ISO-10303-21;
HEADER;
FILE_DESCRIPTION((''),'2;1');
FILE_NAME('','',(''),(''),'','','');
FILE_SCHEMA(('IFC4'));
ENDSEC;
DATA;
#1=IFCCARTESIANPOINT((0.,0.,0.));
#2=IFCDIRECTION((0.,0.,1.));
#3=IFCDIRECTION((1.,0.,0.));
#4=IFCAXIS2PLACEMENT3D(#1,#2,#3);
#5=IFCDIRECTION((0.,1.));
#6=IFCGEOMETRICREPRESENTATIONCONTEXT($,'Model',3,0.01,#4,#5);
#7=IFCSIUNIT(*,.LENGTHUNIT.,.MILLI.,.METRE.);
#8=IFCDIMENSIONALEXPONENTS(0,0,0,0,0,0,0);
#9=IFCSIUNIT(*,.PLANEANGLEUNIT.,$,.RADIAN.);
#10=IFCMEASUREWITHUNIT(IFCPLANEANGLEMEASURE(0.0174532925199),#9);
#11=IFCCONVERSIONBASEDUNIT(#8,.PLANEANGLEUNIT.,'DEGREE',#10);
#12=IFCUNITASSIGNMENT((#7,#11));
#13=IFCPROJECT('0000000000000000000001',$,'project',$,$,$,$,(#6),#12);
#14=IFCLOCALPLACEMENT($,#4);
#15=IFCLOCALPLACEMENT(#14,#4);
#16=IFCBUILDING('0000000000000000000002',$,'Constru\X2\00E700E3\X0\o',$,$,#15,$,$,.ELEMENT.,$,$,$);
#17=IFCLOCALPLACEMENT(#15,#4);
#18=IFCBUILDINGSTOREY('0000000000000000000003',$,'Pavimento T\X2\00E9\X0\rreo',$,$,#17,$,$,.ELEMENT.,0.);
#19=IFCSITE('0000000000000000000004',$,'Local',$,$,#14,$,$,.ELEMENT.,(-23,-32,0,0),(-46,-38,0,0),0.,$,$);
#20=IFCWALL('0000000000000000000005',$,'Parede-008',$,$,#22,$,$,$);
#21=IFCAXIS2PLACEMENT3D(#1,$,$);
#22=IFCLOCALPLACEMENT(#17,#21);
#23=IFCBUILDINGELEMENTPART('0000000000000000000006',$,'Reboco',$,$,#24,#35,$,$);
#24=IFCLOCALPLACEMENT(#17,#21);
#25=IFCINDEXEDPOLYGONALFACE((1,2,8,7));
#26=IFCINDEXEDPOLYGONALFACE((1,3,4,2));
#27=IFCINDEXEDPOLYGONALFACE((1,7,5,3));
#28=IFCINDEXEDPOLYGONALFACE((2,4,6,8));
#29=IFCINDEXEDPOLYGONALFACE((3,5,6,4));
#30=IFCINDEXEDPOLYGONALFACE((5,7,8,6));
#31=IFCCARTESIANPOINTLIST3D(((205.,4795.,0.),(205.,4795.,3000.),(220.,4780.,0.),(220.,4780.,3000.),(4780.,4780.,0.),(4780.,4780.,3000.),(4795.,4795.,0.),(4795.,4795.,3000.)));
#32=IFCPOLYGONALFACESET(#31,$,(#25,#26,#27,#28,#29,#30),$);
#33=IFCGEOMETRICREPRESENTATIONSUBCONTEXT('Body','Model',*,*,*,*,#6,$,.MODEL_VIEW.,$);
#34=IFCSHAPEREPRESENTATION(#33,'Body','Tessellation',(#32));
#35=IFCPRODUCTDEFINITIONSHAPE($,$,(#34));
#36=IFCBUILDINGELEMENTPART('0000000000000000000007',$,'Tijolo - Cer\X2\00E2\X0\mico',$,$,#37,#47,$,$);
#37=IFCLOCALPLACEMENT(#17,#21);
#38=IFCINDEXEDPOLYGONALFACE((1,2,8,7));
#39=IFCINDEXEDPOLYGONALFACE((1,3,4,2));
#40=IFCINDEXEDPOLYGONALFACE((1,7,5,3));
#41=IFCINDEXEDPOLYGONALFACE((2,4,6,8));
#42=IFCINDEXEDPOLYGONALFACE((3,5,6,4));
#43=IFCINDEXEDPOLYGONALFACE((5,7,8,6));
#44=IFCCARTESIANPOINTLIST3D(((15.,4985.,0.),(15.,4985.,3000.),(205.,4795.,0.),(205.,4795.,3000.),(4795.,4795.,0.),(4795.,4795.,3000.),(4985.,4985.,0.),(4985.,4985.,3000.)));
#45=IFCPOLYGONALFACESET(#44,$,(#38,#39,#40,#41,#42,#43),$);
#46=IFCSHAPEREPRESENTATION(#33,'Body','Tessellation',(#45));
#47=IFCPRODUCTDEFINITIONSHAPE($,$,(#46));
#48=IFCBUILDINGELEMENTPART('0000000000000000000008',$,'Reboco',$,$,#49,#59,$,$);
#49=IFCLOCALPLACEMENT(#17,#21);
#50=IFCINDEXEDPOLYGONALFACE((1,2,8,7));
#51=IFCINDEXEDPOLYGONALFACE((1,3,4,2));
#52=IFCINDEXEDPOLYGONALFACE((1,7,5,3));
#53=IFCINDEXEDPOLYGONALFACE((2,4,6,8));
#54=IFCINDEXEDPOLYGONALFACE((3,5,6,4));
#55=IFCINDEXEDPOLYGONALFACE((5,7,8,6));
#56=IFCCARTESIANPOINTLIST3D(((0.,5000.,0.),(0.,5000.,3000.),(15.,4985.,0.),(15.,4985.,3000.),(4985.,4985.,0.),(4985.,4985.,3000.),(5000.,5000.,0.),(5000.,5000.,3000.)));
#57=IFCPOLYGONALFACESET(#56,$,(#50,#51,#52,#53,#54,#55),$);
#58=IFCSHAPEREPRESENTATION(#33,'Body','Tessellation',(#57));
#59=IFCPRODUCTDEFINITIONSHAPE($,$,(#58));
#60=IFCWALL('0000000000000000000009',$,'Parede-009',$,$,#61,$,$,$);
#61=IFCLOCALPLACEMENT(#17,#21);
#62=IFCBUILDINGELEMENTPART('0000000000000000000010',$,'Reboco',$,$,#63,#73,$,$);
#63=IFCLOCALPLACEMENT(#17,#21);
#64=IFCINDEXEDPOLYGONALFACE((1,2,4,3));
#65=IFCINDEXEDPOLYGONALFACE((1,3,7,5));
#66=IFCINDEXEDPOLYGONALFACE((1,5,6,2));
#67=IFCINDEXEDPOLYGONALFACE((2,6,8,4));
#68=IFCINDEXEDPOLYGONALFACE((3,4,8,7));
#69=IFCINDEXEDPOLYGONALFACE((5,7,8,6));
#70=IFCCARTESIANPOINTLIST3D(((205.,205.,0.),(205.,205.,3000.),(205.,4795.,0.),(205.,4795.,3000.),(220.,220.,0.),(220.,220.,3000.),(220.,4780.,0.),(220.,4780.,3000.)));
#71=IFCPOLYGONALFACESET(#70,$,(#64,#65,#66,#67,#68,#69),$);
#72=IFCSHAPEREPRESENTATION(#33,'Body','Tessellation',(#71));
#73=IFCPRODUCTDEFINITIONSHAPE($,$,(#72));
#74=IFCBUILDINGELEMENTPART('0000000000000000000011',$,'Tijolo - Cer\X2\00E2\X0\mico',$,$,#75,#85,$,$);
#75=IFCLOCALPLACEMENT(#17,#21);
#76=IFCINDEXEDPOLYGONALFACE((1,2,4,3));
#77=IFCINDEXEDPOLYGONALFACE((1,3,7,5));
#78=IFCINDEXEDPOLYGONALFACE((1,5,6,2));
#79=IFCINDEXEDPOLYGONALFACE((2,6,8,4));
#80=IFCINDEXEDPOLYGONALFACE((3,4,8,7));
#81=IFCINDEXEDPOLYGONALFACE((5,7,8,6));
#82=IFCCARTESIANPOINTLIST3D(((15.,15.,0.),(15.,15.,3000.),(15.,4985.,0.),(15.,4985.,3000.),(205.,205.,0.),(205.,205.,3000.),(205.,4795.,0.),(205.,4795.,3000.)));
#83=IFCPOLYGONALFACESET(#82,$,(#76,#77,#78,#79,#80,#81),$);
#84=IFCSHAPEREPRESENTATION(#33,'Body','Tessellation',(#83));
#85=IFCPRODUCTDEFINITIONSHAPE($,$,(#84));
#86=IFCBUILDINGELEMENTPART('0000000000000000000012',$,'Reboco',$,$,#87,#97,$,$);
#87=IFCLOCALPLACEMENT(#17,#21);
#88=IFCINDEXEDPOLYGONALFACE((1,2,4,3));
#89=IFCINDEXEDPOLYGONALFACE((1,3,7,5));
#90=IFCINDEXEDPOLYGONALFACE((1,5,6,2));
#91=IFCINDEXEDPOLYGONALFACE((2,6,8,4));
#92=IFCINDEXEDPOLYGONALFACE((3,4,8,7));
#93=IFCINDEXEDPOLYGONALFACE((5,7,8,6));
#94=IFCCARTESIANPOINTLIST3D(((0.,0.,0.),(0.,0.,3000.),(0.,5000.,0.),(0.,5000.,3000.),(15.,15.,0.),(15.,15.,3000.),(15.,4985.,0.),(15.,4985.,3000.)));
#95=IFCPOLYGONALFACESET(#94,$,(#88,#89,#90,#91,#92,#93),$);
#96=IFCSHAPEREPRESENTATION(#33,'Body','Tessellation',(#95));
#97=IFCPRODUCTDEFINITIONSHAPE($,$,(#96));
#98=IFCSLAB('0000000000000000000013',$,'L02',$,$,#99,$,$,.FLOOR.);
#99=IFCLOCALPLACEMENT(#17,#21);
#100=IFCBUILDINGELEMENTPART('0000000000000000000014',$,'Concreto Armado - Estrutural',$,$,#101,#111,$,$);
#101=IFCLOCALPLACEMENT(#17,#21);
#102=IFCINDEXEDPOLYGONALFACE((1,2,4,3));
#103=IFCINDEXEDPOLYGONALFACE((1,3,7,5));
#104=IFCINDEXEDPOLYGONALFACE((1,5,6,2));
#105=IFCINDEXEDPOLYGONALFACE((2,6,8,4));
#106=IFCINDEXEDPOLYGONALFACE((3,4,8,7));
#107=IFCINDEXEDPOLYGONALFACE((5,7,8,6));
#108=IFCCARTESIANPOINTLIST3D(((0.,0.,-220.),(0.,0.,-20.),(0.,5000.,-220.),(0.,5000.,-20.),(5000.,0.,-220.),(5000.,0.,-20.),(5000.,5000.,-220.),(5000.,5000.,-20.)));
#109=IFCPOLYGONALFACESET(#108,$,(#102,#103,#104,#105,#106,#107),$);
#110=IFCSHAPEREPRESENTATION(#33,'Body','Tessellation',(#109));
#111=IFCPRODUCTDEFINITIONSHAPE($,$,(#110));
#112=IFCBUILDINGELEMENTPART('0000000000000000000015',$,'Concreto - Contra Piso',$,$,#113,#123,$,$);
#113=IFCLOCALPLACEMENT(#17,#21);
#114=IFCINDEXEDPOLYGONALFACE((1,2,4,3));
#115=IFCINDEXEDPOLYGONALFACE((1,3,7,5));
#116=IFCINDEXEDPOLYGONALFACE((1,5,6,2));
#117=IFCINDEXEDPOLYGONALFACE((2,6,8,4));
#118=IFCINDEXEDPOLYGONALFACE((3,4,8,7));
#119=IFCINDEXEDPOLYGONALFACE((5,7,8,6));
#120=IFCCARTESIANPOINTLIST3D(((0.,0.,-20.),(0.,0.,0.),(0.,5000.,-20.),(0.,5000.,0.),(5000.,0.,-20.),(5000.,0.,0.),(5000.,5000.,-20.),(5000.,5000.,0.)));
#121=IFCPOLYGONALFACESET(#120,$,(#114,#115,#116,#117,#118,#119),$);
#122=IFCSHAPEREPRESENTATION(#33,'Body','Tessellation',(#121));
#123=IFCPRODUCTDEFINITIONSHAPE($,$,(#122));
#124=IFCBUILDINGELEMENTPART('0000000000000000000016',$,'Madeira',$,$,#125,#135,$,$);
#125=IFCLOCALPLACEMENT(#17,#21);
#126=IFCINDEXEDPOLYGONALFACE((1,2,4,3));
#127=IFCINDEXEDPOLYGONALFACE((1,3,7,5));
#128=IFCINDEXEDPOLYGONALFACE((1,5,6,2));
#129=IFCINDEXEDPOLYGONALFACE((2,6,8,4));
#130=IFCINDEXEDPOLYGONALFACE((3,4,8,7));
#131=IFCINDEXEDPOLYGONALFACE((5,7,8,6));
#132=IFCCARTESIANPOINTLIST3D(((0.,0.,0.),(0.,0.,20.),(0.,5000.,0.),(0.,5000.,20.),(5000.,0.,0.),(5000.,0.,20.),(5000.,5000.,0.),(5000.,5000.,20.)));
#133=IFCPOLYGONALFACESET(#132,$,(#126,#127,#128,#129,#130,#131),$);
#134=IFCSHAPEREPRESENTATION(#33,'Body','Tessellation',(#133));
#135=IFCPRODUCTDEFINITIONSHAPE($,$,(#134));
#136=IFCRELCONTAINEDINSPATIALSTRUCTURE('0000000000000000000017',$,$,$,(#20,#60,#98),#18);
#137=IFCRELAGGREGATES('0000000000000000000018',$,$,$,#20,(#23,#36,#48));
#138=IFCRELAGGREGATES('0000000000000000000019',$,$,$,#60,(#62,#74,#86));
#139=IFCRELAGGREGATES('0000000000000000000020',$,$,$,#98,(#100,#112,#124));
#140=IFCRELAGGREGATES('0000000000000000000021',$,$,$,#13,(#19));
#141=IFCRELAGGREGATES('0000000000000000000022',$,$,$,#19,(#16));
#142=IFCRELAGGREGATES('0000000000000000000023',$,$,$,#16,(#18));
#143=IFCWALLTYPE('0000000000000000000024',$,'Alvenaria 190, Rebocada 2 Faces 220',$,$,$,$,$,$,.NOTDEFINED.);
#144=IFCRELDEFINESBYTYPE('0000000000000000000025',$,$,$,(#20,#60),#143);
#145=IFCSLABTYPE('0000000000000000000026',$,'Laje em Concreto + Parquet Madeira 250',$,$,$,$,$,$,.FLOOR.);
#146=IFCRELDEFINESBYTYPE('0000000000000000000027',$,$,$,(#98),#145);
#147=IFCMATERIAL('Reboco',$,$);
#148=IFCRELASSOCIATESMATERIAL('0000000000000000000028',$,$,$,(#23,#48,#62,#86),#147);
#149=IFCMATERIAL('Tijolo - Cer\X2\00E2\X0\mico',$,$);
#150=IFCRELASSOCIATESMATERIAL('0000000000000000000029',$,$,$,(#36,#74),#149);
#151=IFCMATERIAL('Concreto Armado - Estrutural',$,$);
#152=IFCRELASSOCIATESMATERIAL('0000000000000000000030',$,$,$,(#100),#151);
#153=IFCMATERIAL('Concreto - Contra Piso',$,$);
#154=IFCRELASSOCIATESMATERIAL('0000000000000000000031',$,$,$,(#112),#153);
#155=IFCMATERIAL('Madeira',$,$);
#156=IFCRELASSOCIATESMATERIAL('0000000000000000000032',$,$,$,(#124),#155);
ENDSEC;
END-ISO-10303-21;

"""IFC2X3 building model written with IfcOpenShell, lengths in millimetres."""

from ifc_helpers import new_model, entity, si_unit, converted_unit, direction, frame, origin_with_axes, place, context, subcontext, project, spatial, polyline, outline, extrude, material, type_object, element, aggregate, save


model = new_model("IFC2X3")

# Units and contexts
model_context = context("Model", 3, precision=0.01, world=origin_with_axes(), true_north=direction((0.0, 1.0)))
body_context = subcontext(model_context, "Body", "Model", "MODEL_VIEW")
ifc_project = project(units=[si_unit("LENGTHUNIT", "METRE", prefix="MILLI"), converted_unit("PLANEANGLEUNIT", "DEGREE", entity("IfcPlaneAngleMeasure", 0.0174532925199), si_unit("PLANEANGLEUNIT", "RADIAN"), dimensions=[0, 0, 0, 0, 0, 0, 0])], contexts=[model_context])

# Site, building, storey
site_placement = place(None, origin_with_axes())
site = spatial("IfcSite", under=ifc_project, at=site_placement, Name="Local", CompositionType="ELEMENT", RefLatitude=(-23, -32, 0, 0), RefLongitude=(-46, -38, 0, 0), RefElevation=0.0)
building_placement = place(site_placement, origin_with_axes())
building = spatial("IfcBuilding", under=site, at=building_placement, Name="Construção", CompositionType="ELEMENT")
storey_placement = place(building_placement, origin_with_axes())
storey = spatial("IfcBuildingStorey", under=building, at=storey_placement, Name="Pavimento Térreo", CompositionType="ELEMENT", Elevation=0.0)

# Walls, building element parts
wall_type = type_object("IfcWallType", Name="Alvenaria 190, Rebocada 2 Faces 220", PredefinedType="NOTDEFINED")
wall_1_placement = place(storey_placement, frame((5000.0, 5000.0, 0.0), z_axis=(0.0, 0.0, 1.0), x_axis=(-1.0, 0.0, 0.0)))
wall_1 = element("IfcWall", 1, at=wall_1_placement, inside=storey, type_object=wall_type, Name="Parede-008")
ifc_material_1 = material(Name="Reboco")
building_element_part_1_placement = place(wall_1_placement, origin_with_axes())
building_element_part_1 = element("IfcBuildingElementPart", 2, at=building_element_part_1_placement, material=ifc_material_1, Name="Reboco", context=body_context, shape_type="SweptSolid", body=[
    extrude(outline(polyline([(205.0, 205.0), (4795.0, 205.0), (4780.0, 220.0), (220.0, 220.0), (205.0, 205.0)])), origin_with_axes(), (0.0, 0.0, 1.0), 3000.0),
])
ifc_material_2 = material(Name="Tijolo - Cerâmico")
building_element_part_2_placement = place(wall_1_placement, origin_with_axes())
building_element_part_2 = element("IfcBuildingElementPart", 3, at=building_element_part_2_placement, material=ifc_material_2, Name="Tijolo - Cerâmico", context=body_context, shape_type="SweptSolid", body=[
    extrude(outline(polyline([(15.0, 15.0), (4985.0, 15.0), (4795.0, 205.0), (205.0, 205.0), (15.0, 15.0)])), origin_with_axes(), (0.0, 0.0, 1.0), 3000.0),
])
building_element_part_3_placement = place(wall_1_placement, origin_with_axes())
building_element_part_3 = element("IfcBuildingElementPart", 4, at=building_element_part_3_placement, material=ifc_material_1, Name="Reboco", context=body_context, shape_type="SweptSolid", body=[
    extrude(outline(polyline([(0.0, 0.0), (5000.0, 0.0), (4985.0, 15.0), (15.0, 15.0), (0.0, 0.0)])), origin_with_axes(), (0.0, 0.0, 1.0), 3000.0),
])
aggregate(wall_1, [building_element_part_1, building_element_part_2, building_element_part_3])
wall_2_placement = place(storey_placement, frame((0.0, 5000.0, 0.0), z_axis=(0.0, 0.0, 1.0), x_axis=(0.0, -1.0, 0.0)))
wall_2 = element("IfcWall", 5, at=wall_2_placement, inside=storey, type_object=wall_type, Name="Parede-009")
building_element_part_4_placement = place(wall_2_placement, origin_with_axes())
building_element_part_4 = element("IfcBuildingElementPart", 6, at=building_element_part_4_placement, material=ifc_material_1, Name="Reboco", context=body_context, shape_type="SweptSolid", body=[
    extrude(outline(polyline([(205.0, 205.0), (4795.0, 205.0), (4780.0, 220.0), (220.0, 220.0), (205.0, 205.0)])), origin_with_axes(), (0.0, 0.0, 1.0), 3000.0),
])
building_element_part_5_placement = place(wall_2_placement, origin_with_axes())
building_element_part_5 = element("IfcBuildingElementPart", 7, at=building_element_part_5_placement, material=ifc_material_2, Name="Tijolo - Cerâmico", context=body_context, shape_type="SweptSolid", body=[
    extrude(outline(polyline([(15.0, 15.0), (4985.0, 15.0), (4795.0, 205.0), (205.0, 205.0), (15.0, 15.0)])), origin_with_axes(), (0.0, 0.0, 1.0), 3000.0),
])
building_element_part_6_placement = place(wall_2_placement, origin_with_axes())
building_element_part_6 = element("IfcBuildingElementPart", 8, at=building_element_part_6_placement, material=ifc_material_1, Name="Reboco", context=body_context, shape_type="SweptSolid", body=[
    extrude(outline(polyline([(0.0, 0.0), (5000.0, 0.0), (4985.0, 15.0), (15.0, 15.0), (0.0, 0.0)])), origin_with_axes(), (0.0, 0.0, 1.0), 3000.0),
])
aggregate(wall_2, [building_element_part_4, building_element_part_5, building_element_part_6])

# Slab, building element parts
slab_type = type_object("IfcSlabType", Name="Laje em Concreto + Parquet Madeira 250", PredefinedType="FLOOR")
slab_placement = place(storey_placement, frame((0.0, 0.0, 20.0), z_axis=(0.0, 0.0, 1.0), x_axis=(1.0, 0.0, 0.0)))
slab = element("IfcSlab", 9, at=slab_placement, inside=storey, type_object=slab_type, Name="L02", PredefinedType="FLOOR")
ifc_material_3 = material(Name="Concreto Armado - Estrutural")
building_element_part_7_placement = place(slab_placement, origin_with_axes())
building_element_part_7 = element("IfcBuildingElementPart", 10, at=building_element_part_7_placement, material=ifc_material_3, Name="Concreto Armado - Estrutural", context=body_context, shape_type="SweptSolid", body=[
    extrude(outline(polyline([(0.0, 0.0), (5000.0, 0.0), (5000.0, 5000.0), (0.0, 5000.0), (0.0, 0.0)])), frame((0.0, 0.0, -240.0), z_axis=(0.0, 0.0, 1.0), x_axis=(1.0, 0.0, 0.0)), (0.0, 0.0, 1.0), 200.0),
])
ifc_material_4 = material(Name="Concreto - Contra Piso")
building_element_part_8_placement = place(slab_placement, origin_with_axes())
building_element_part_8 = element("IfcBuildingElementPart", 11, at=building_element_part_8_placement, material=ifc_material_4, Name="Concreto - Contra Piso", context=body_context, shape_type="SweptSolid", body=[
    extrude(outline(polyline([(0.0, 0.0), (5000.0, 0.0), (5000.0, 5000.0), (0.0, 5000.0), (0.0, 0.0)])), frame((0.0, 0.0, -40.0), z_axis=(0.0, 0.0, 1.0), x_axis=(1.0, 0.0, 0.0)), (0.0, 0.0, 1.0), 20.0),
])
ifc_material_5 = material(Name="Madeira")
building_element_part_9_placement = place(slab_placement, origin_with_axes())
building_element_part_9 = element("IfcBuildingElementPart", 12, at=building_element_part_9_placement, material=ifc_material_5, Name="Madeira", context=body_context, shape_type="SweptSolid", body=[
    extrude(outline(polyline([(0.0, 0.0), (5000.0, 0.0), (5000.0, 5000.0), (0.0, 5000.0), (0.0, 0.0)])), frame((0.0, 0.0, -20.0), z_axis=(0.0, 0.0, 1.0), x_axis=(1.0, 0.0, 0.0)), (0.0, 0.0, 1.0), 20.0),
])
aggregate(slab, [building_element_part_7, building_element_part_8, building_element_part_9])

save(model, "model.ifc")
